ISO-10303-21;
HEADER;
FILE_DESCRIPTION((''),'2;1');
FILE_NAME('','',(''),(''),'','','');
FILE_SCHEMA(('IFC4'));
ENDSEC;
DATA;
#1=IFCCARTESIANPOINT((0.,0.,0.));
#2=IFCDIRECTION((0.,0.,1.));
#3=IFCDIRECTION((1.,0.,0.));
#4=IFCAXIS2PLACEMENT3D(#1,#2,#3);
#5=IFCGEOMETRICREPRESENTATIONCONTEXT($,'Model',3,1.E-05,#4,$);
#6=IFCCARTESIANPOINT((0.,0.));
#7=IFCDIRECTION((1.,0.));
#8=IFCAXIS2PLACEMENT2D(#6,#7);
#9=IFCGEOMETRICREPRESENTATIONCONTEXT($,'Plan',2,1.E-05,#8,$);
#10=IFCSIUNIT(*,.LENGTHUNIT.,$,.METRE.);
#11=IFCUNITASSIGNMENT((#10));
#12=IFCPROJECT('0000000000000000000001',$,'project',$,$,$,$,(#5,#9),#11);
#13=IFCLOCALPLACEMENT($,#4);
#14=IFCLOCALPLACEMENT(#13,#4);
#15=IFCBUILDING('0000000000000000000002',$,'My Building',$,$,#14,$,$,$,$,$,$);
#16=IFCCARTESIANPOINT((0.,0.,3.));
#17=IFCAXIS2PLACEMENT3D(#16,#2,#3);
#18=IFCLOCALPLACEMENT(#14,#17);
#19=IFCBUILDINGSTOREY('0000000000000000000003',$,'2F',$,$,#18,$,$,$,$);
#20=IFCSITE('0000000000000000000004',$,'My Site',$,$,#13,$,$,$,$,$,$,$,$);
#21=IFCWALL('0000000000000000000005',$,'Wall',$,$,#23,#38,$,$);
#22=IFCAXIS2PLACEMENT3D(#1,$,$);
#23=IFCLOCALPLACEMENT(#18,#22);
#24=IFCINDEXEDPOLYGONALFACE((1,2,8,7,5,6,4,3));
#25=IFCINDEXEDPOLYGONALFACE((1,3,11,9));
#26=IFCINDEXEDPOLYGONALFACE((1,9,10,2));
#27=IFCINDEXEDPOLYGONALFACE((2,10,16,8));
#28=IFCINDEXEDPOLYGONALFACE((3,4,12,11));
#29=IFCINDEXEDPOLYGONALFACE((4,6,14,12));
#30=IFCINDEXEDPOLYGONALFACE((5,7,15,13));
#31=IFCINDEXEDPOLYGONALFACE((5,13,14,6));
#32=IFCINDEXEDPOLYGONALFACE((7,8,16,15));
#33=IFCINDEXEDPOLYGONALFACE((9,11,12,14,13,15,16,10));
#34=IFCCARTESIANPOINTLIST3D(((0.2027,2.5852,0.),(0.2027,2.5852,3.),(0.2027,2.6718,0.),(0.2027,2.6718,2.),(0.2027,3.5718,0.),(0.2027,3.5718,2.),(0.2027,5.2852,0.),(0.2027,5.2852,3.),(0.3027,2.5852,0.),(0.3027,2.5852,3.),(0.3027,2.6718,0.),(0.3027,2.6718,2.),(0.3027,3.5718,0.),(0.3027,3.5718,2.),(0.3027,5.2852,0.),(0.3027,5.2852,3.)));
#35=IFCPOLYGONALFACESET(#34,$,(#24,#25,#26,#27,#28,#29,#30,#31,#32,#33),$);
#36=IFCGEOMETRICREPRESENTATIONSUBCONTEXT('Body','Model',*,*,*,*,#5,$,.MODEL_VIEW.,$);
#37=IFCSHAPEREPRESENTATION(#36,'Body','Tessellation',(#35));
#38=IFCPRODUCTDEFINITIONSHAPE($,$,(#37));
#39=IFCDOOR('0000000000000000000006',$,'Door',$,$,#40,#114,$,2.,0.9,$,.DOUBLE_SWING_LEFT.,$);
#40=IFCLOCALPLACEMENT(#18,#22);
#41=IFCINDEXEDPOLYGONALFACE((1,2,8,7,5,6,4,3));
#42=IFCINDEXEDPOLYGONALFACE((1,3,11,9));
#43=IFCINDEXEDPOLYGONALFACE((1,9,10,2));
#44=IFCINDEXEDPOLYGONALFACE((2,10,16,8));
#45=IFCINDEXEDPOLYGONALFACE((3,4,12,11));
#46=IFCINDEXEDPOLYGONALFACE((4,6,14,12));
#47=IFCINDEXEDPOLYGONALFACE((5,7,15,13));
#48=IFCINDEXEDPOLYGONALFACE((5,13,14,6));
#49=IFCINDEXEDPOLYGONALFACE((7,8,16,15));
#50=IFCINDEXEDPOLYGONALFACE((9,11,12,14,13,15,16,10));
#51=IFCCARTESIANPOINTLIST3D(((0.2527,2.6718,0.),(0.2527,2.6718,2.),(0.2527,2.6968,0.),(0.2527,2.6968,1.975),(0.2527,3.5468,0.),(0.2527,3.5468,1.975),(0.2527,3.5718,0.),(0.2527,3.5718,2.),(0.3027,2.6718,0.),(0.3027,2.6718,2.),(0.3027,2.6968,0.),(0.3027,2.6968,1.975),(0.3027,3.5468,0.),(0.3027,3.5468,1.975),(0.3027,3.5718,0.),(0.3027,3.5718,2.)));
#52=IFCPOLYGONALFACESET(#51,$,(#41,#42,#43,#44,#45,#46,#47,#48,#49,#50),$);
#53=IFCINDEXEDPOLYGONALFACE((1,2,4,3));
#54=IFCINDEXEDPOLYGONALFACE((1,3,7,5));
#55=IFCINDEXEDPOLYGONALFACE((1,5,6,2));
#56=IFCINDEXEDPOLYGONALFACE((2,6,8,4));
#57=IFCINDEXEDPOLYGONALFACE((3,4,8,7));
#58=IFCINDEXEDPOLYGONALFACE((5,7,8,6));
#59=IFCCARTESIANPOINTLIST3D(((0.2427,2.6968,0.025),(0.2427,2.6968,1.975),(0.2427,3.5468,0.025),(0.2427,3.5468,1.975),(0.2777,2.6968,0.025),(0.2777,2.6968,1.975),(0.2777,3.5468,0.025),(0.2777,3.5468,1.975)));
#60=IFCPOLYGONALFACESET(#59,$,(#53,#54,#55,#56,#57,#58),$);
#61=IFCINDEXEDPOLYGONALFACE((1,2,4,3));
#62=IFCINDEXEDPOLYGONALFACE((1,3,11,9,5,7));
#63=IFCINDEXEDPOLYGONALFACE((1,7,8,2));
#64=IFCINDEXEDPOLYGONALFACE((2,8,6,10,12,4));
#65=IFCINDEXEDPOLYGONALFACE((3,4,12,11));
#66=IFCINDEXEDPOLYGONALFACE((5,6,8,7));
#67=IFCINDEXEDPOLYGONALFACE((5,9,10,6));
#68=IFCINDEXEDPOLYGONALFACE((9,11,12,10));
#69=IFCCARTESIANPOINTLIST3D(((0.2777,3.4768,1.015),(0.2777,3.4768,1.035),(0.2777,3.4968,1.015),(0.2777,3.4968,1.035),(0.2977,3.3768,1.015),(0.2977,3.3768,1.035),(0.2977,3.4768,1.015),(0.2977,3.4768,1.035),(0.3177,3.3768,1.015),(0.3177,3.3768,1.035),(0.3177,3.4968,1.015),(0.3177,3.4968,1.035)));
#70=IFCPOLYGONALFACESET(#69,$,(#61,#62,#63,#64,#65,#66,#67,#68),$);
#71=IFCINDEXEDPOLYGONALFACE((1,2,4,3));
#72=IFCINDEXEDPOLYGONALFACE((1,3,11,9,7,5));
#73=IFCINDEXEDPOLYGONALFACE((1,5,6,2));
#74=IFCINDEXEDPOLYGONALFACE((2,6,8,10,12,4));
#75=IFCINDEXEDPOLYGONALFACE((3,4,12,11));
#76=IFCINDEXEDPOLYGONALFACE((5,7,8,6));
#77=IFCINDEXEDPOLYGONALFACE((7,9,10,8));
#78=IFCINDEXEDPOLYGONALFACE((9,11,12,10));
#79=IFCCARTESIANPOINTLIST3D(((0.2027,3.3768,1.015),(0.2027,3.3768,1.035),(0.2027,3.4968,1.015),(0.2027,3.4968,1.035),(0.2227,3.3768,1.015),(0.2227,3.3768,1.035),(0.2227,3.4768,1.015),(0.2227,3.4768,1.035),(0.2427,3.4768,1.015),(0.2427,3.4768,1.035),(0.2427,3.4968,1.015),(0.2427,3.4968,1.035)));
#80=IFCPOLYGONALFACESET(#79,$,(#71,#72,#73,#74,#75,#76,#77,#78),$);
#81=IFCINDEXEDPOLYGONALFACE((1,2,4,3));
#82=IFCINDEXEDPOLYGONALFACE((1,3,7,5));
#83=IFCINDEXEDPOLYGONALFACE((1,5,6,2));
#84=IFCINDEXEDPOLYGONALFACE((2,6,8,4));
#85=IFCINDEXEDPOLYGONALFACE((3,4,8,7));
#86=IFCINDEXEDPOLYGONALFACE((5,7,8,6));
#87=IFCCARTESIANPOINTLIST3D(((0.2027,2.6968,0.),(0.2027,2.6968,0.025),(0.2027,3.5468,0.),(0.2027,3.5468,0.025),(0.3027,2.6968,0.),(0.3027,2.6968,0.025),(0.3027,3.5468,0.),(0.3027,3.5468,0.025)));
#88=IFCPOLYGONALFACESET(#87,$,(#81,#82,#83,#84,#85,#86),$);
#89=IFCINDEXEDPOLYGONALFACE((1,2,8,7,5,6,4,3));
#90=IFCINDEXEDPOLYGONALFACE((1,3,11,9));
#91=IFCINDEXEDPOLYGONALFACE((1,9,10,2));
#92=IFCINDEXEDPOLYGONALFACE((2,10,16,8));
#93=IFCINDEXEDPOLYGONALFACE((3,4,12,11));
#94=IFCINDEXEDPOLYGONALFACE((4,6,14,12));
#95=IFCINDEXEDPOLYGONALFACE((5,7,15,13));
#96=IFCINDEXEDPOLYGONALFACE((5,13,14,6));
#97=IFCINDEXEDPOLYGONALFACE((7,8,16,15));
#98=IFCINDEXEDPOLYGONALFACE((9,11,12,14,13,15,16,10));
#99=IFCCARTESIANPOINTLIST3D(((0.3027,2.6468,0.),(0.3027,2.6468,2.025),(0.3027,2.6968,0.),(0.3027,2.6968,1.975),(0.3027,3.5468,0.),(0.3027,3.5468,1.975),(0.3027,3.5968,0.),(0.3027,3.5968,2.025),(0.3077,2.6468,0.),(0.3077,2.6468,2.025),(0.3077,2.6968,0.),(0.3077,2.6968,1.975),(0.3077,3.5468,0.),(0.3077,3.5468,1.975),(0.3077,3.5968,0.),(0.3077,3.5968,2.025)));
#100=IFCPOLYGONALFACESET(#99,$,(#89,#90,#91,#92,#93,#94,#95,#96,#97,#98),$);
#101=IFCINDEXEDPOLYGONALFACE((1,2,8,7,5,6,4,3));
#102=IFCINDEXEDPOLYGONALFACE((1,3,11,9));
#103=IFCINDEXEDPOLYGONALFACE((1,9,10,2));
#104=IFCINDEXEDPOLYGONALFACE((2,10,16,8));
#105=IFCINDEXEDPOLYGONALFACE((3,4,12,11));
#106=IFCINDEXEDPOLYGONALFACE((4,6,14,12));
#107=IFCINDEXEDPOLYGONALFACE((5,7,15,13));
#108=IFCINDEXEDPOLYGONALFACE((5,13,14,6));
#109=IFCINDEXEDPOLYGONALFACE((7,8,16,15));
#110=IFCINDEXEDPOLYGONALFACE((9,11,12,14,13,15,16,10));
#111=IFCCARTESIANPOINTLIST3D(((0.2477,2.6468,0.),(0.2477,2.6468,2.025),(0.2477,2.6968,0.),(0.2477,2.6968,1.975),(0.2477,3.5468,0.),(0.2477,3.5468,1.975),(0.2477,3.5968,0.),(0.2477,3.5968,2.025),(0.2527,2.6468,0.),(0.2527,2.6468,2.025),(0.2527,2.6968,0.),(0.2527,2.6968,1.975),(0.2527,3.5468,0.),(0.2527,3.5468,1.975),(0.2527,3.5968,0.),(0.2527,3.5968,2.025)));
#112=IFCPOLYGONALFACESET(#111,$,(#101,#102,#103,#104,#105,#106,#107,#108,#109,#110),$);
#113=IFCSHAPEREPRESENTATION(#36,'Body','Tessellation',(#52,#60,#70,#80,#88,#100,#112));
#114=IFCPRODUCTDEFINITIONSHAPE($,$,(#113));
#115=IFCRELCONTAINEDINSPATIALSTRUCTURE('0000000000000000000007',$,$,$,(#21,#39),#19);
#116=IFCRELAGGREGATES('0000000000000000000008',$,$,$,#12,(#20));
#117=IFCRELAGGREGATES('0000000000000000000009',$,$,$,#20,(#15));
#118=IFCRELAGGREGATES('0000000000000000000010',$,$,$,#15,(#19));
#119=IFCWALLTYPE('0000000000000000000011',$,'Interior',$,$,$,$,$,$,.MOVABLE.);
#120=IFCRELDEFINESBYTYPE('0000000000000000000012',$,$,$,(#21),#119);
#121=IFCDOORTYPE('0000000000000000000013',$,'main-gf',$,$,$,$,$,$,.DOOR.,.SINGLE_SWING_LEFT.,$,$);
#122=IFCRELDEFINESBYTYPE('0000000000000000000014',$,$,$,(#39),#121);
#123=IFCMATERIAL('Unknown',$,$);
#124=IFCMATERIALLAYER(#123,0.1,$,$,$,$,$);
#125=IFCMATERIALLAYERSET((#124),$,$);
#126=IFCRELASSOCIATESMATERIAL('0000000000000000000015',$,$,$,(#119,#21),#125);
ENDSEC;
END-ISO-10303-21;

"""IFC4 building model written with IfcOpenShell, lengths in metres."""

from ifc_helpers import new_model, entity, si_unit, frame, origin_with_axes, origin_2d_with_axis, place, context, subcontext, project, spatial, line, indexed_curve, outline, extrude, shape, source, transform, mapped, material, layer, layer_set, layer_usage, type_object, type_shapes, element, fill, save


model = new_model("IFC4")

# Units and contexts
model_context = context("Model", 3, precision=1e-05, world=origin_with_axes())
plan_context = context("Plan", 2, precision=1e-05, world=origin_2d_with_axis())
body_context_1 = subcontext(model_context, "Body", "Model", "MODEL_VIEW")
body_context_2 = subcontext(plan_context, "Body", "Plan", "PLAN_VIEW")
ifc_project = project(units=[si_unit("LENGTHUNIT", "METRE")], contexts=[model_context, plan_context])

# Site, building, storey
site_placement = place(None, origin_with_axes())
site = spatial("IfcSite", under=ifc_project, at=site_placement, Name="My Site")
building_placement = place(site_placement, origin_with_axes())
building = spatial("IfcBuilding", under=site, at=building_placement, Name="My Building")
storey_placement = place(building_placement, frame((0.0, 0.0, 3.0), z_axis=(0.0, 0.0, 1.0), x_axis=(1.0, 0.0, 0.0)))
storey = spatial("IfcBuildingStorey", under=building, at=storey_placement, Name="2F")

# Shared definitions
ifc_material = material(Name="Unknown")

# Shared definitions
ifc_layer_1 = layer(ifc_material, 0.1)
ifc_layer_set_1 = layer_set([ifc_layer_1])
wall_type = type_object("IfcWallType", Name="Interior", PredefinedType="MOVABLE", material=ifc_layer_set_1)

# Shared definitions
shared_shape_1 = source(origin_with_axes(), body_context_1, "Body", "SweptSolid", [
    extrude(outline(indexed_curve([(0.0, 0.0), (0.9, 0.0), (0.9, 2.0), (0.0, 2.0)], segments=[line(1, 2, 3, 4, 1)])), frame((0.0, -0.6, 0.0), z_axis=(0.0, -1.0, 0.0), x_axis=(1.0, 0.0, 0.0)), (0.0, 0.0, -1.0), 1.2),
])
door_type = type_object("IfcDoorType", Name="main-gf", OperationType="SINGLE_SWING_LEFT", PredefinedType="DOOR")
shared_shape_2 = source(origin_with_axes(), body_context_1, "Body", "SweptSolid", [
    extrude(outline(indexed_curve([(0.0, 0.0), (0.0, 2.0), (0.9, 2.0), (0.9, 0.0), (0.875, 0.0), (0.875, 1.975), (0.025, 1.975), (0.025, 0.0)], segments=[line(1, 2, 3, 4, 5, 6, 7, 8, 1)])), frame((0.0, 0.0, 0.0), z_axis=(0.0, -1.0, 0.0), x_axis=(1.0, 0.0, 0.0)), (0.0, 0.0, -1.0), 0.05),
    extrude(outline(indexed_curve([(0.0, 0.0), (0.85, 0.0), (0.85, 0.035), (0.0, 0.035)], segments=[line(1, 2, 3, 4, 1)])), frame((0.025, 0.025, 0.025), z_axis=(0.0, 0.0, 1.0), x_axis=(1.0, 0.0, 0.0)), (0.0, 0.0, 1.0), 1.95),
    extrude(outline(indexed_curve([(0.0, 0.0), (0.0, -0.04), (-0.12, -0.04), (-0.12, -0.02), (-0.02, -0.02), (-0.02, 0.0)], segments=[line(1, 2, 3, 4, 5, 6, 1)])), frame((0.825, 0.025, 1.015), z_axis=(0.0, 0.0, 1.0), x_axis=(1.0, 0.0, 0.0)), (0.0, 0.0, 1.0), 0.02),
    extrude(outline(indexed_curve([(0.0, 0.0), (0.0, 0.04), (-0.12, 0.04), (-0.12, 0.02), (-0.02, 0.02), (-0.02, 0.0)], segments=[line(1, 2, 3, 4, 5, 6, 1)])), frame((0.825, 0.06, 1.015), z_axis=(0.0, 0.0, 1.0), x_axis=(1.0, 0.0, 0.0)), (0.0, 0.0, 1.0), 0.02),
    extrude(outline(indexed_curve([(0.0, 0.0), (0.85, 0.0), (0.85, 0.1), (0.0, 0.1)], segments=[line(1, 2, 3, 4, 1)])), frame((0.025, 0.0, 0.0), z_axis=(0.0, 0.0, 1.0), x_axis=(1.0, 0.0, 0.0)), (0.0, 0.0, 1.0), 0.025),
    extrude(outline(indexed_curve([(0.0, 0.0), (0.0, 2.025), (0.95, 2.025), (0.95, 0.0), (0.9, 0.0), (0.9, 1.975), (0.05, 1.975), (0.05, 0.0)], segments=[line(1, 2, 3, 4, 5, 6, 7, 8, 1)])), frame((-0.025, -0.005, 0.0), z_axis=(0.0, -1.0, 0.0), x_axis=(1.0, 0.0, 0.0)), (0.0, 0.0, -1.0), 0.005),
    extrude(outline(indexed_curve([(0.0, 0.0), (0.0, 2.025), (0.95, 2.025), (0.95, 0.0), (0.9, 0.0), (0.9, 1.975), (0.05, 1.975), (0.05, 0.0)], segments=[line(1, 2, 3, 4, 5, 6, 7, 8, 1)])), frame((-0.025, 0.05, 0.0), z_axis=(0.0, -1.0, 0.0), x_axis=(1.0, 0.0, 0.0)), (0.0, 0.0, -1.0), 0.005),
])
shared_shape_3 = source(origin_with_axes(), body_context_2, "Body", "Curve2D", [
    entity("IfcIndexedPolyCurve", entity("IfcCartesianPointList2D", [[0.0, 0.0], [0.025, 0.0], [0.025, 0.05], [0.0, 0.05]]), [entity("IfcLineIndex", [1, 2, 3, 4, 1])]),
    entity("IfcIndexedPolyCurve", entity("IfcCartesianPointList2D", [[0.9, 0.0], [0.875, 0.0], [0.875, 0.05], [0.9, 0.05]]), [entity("IfcLineIndex", [1, 2, 3, 4, 1])]),
    entity("IfcIndexedPolyCurve", entity("IfcCartesianPointList2D", [[0.025, 0.05], [0.025, -0.8], [0.06, -0.8]])),
    entity("IfcTrimmedCurve", entity("IfcEllipse", entity("IfcAxis2Placement2D", entity("IfcCartesianPoint", [0.06, 0.05]), entity("IfcDirection", [1.0, 0.0])), 0.815, 0.85), [entity("IfcCartesianPoint", [0.06, -0.8])], [entity("IfcCartesianPoint", [0.06, 0.9])], True, "CARTESIAN"),
    entity("IfcIndexedPolyCurve", entity("IfcCartesianPointList2D", [[0.025, 0.05], [0.06, 0.05], [0.06, 0.9], [0.025, 0.9]]), [entity("IfcLineIndex", [1, 2, 3, 4, 1])]),
])
type_shapes(door_type, [shared_shape_2, shared_shape_3])

# Wall, opening, door
ifc_layer_usage_1 = layer_usage(ifc_layer_set_1, "AXIS2", "POSITIVE", 0.0)
wall_1_placement = place(storey_placement, frame((0.3027, 2.5852, 0.0), z_axis=(0.0, 0.0, 1.0), x_axis=(0.0, 1.0, 0.0)))
wall_1 = element("IfcWall", 1, at=wall_1_placement, inside=storey, type_object=wall_type, material=ifc_layer_usage_1, Name="Wall", context=body_context_1, shape_type="SweptSolid", body=[
    extrude(outline(indexed_curve([(0.0, 0.0), (0.0, 0.1), (2.7, 0.1), (2.7, 0.0)], segments=[line(1, 2, 3, 4, 1)])), origin_with_axes(), (0.0, 0.0, 1.0), 3.0),
])
opening_1_placement = place(wall_1_placement, frame((0.0866, 0.0, 0.0), z_axis=(0.0, 0.0, 1.0), x_axis=(1.0, 0.0, 0.0)))
opening_1 = element("IfcOpeningElement", 2, at=opening_1_placement, cuts=wall_1, PredefinedType="OPENING", context=body_context_1, shape_type="MappedRepresentation", body=[
    mapped(shared_shape_1, transform((0.0, 0.0, 0.0), x_axis=(1.0, 0.0, 0.0), y_axis=(0.0, 1.0, 0.0), z_axis=(0.0, 0.0, 1.0), scale=1.0)),
])
door_1_placement = place(opening_1_placement, frame((0.0, 0.0, 0.0), z_axis=(0.0, 0.0, 1.0), x_axis=(1.0, 0.0, 0.0)))
door_1 = element("IfcDoor", 3, at=door_1_placement, inside=storey, type_object=door_type, Name="Door", OperationType="DOUBLE_SWING_LEFT", OverallHeight=2.0, OverallWidth=0.9, shapes=[
    shape(body_context_1, "Body", "MappedRepresentation", [mapped(shared_shape_2, transform((0.0, 0.0, 0.0), x_axis=(1.0, 0.0, 0.0), y_axis=(0.0, 1.0, 0.0), z_axis=(0.0, 0.0, 1.0), scale=1.0))]),
    shape(body_context_2, "Body", "MappedRepresentation", [mapped(shared_shape_3, transform((0.0, 0.0, 0.0), x_axis=(1.0, 0.0, 0.0), y_axis=(0.0, 1.0, 0.0), z_axis=(0.0, 0.0, 1.0), scale=1.0))]),
])
fill(opening_1, door_1)

save(model, "model.ifc")
